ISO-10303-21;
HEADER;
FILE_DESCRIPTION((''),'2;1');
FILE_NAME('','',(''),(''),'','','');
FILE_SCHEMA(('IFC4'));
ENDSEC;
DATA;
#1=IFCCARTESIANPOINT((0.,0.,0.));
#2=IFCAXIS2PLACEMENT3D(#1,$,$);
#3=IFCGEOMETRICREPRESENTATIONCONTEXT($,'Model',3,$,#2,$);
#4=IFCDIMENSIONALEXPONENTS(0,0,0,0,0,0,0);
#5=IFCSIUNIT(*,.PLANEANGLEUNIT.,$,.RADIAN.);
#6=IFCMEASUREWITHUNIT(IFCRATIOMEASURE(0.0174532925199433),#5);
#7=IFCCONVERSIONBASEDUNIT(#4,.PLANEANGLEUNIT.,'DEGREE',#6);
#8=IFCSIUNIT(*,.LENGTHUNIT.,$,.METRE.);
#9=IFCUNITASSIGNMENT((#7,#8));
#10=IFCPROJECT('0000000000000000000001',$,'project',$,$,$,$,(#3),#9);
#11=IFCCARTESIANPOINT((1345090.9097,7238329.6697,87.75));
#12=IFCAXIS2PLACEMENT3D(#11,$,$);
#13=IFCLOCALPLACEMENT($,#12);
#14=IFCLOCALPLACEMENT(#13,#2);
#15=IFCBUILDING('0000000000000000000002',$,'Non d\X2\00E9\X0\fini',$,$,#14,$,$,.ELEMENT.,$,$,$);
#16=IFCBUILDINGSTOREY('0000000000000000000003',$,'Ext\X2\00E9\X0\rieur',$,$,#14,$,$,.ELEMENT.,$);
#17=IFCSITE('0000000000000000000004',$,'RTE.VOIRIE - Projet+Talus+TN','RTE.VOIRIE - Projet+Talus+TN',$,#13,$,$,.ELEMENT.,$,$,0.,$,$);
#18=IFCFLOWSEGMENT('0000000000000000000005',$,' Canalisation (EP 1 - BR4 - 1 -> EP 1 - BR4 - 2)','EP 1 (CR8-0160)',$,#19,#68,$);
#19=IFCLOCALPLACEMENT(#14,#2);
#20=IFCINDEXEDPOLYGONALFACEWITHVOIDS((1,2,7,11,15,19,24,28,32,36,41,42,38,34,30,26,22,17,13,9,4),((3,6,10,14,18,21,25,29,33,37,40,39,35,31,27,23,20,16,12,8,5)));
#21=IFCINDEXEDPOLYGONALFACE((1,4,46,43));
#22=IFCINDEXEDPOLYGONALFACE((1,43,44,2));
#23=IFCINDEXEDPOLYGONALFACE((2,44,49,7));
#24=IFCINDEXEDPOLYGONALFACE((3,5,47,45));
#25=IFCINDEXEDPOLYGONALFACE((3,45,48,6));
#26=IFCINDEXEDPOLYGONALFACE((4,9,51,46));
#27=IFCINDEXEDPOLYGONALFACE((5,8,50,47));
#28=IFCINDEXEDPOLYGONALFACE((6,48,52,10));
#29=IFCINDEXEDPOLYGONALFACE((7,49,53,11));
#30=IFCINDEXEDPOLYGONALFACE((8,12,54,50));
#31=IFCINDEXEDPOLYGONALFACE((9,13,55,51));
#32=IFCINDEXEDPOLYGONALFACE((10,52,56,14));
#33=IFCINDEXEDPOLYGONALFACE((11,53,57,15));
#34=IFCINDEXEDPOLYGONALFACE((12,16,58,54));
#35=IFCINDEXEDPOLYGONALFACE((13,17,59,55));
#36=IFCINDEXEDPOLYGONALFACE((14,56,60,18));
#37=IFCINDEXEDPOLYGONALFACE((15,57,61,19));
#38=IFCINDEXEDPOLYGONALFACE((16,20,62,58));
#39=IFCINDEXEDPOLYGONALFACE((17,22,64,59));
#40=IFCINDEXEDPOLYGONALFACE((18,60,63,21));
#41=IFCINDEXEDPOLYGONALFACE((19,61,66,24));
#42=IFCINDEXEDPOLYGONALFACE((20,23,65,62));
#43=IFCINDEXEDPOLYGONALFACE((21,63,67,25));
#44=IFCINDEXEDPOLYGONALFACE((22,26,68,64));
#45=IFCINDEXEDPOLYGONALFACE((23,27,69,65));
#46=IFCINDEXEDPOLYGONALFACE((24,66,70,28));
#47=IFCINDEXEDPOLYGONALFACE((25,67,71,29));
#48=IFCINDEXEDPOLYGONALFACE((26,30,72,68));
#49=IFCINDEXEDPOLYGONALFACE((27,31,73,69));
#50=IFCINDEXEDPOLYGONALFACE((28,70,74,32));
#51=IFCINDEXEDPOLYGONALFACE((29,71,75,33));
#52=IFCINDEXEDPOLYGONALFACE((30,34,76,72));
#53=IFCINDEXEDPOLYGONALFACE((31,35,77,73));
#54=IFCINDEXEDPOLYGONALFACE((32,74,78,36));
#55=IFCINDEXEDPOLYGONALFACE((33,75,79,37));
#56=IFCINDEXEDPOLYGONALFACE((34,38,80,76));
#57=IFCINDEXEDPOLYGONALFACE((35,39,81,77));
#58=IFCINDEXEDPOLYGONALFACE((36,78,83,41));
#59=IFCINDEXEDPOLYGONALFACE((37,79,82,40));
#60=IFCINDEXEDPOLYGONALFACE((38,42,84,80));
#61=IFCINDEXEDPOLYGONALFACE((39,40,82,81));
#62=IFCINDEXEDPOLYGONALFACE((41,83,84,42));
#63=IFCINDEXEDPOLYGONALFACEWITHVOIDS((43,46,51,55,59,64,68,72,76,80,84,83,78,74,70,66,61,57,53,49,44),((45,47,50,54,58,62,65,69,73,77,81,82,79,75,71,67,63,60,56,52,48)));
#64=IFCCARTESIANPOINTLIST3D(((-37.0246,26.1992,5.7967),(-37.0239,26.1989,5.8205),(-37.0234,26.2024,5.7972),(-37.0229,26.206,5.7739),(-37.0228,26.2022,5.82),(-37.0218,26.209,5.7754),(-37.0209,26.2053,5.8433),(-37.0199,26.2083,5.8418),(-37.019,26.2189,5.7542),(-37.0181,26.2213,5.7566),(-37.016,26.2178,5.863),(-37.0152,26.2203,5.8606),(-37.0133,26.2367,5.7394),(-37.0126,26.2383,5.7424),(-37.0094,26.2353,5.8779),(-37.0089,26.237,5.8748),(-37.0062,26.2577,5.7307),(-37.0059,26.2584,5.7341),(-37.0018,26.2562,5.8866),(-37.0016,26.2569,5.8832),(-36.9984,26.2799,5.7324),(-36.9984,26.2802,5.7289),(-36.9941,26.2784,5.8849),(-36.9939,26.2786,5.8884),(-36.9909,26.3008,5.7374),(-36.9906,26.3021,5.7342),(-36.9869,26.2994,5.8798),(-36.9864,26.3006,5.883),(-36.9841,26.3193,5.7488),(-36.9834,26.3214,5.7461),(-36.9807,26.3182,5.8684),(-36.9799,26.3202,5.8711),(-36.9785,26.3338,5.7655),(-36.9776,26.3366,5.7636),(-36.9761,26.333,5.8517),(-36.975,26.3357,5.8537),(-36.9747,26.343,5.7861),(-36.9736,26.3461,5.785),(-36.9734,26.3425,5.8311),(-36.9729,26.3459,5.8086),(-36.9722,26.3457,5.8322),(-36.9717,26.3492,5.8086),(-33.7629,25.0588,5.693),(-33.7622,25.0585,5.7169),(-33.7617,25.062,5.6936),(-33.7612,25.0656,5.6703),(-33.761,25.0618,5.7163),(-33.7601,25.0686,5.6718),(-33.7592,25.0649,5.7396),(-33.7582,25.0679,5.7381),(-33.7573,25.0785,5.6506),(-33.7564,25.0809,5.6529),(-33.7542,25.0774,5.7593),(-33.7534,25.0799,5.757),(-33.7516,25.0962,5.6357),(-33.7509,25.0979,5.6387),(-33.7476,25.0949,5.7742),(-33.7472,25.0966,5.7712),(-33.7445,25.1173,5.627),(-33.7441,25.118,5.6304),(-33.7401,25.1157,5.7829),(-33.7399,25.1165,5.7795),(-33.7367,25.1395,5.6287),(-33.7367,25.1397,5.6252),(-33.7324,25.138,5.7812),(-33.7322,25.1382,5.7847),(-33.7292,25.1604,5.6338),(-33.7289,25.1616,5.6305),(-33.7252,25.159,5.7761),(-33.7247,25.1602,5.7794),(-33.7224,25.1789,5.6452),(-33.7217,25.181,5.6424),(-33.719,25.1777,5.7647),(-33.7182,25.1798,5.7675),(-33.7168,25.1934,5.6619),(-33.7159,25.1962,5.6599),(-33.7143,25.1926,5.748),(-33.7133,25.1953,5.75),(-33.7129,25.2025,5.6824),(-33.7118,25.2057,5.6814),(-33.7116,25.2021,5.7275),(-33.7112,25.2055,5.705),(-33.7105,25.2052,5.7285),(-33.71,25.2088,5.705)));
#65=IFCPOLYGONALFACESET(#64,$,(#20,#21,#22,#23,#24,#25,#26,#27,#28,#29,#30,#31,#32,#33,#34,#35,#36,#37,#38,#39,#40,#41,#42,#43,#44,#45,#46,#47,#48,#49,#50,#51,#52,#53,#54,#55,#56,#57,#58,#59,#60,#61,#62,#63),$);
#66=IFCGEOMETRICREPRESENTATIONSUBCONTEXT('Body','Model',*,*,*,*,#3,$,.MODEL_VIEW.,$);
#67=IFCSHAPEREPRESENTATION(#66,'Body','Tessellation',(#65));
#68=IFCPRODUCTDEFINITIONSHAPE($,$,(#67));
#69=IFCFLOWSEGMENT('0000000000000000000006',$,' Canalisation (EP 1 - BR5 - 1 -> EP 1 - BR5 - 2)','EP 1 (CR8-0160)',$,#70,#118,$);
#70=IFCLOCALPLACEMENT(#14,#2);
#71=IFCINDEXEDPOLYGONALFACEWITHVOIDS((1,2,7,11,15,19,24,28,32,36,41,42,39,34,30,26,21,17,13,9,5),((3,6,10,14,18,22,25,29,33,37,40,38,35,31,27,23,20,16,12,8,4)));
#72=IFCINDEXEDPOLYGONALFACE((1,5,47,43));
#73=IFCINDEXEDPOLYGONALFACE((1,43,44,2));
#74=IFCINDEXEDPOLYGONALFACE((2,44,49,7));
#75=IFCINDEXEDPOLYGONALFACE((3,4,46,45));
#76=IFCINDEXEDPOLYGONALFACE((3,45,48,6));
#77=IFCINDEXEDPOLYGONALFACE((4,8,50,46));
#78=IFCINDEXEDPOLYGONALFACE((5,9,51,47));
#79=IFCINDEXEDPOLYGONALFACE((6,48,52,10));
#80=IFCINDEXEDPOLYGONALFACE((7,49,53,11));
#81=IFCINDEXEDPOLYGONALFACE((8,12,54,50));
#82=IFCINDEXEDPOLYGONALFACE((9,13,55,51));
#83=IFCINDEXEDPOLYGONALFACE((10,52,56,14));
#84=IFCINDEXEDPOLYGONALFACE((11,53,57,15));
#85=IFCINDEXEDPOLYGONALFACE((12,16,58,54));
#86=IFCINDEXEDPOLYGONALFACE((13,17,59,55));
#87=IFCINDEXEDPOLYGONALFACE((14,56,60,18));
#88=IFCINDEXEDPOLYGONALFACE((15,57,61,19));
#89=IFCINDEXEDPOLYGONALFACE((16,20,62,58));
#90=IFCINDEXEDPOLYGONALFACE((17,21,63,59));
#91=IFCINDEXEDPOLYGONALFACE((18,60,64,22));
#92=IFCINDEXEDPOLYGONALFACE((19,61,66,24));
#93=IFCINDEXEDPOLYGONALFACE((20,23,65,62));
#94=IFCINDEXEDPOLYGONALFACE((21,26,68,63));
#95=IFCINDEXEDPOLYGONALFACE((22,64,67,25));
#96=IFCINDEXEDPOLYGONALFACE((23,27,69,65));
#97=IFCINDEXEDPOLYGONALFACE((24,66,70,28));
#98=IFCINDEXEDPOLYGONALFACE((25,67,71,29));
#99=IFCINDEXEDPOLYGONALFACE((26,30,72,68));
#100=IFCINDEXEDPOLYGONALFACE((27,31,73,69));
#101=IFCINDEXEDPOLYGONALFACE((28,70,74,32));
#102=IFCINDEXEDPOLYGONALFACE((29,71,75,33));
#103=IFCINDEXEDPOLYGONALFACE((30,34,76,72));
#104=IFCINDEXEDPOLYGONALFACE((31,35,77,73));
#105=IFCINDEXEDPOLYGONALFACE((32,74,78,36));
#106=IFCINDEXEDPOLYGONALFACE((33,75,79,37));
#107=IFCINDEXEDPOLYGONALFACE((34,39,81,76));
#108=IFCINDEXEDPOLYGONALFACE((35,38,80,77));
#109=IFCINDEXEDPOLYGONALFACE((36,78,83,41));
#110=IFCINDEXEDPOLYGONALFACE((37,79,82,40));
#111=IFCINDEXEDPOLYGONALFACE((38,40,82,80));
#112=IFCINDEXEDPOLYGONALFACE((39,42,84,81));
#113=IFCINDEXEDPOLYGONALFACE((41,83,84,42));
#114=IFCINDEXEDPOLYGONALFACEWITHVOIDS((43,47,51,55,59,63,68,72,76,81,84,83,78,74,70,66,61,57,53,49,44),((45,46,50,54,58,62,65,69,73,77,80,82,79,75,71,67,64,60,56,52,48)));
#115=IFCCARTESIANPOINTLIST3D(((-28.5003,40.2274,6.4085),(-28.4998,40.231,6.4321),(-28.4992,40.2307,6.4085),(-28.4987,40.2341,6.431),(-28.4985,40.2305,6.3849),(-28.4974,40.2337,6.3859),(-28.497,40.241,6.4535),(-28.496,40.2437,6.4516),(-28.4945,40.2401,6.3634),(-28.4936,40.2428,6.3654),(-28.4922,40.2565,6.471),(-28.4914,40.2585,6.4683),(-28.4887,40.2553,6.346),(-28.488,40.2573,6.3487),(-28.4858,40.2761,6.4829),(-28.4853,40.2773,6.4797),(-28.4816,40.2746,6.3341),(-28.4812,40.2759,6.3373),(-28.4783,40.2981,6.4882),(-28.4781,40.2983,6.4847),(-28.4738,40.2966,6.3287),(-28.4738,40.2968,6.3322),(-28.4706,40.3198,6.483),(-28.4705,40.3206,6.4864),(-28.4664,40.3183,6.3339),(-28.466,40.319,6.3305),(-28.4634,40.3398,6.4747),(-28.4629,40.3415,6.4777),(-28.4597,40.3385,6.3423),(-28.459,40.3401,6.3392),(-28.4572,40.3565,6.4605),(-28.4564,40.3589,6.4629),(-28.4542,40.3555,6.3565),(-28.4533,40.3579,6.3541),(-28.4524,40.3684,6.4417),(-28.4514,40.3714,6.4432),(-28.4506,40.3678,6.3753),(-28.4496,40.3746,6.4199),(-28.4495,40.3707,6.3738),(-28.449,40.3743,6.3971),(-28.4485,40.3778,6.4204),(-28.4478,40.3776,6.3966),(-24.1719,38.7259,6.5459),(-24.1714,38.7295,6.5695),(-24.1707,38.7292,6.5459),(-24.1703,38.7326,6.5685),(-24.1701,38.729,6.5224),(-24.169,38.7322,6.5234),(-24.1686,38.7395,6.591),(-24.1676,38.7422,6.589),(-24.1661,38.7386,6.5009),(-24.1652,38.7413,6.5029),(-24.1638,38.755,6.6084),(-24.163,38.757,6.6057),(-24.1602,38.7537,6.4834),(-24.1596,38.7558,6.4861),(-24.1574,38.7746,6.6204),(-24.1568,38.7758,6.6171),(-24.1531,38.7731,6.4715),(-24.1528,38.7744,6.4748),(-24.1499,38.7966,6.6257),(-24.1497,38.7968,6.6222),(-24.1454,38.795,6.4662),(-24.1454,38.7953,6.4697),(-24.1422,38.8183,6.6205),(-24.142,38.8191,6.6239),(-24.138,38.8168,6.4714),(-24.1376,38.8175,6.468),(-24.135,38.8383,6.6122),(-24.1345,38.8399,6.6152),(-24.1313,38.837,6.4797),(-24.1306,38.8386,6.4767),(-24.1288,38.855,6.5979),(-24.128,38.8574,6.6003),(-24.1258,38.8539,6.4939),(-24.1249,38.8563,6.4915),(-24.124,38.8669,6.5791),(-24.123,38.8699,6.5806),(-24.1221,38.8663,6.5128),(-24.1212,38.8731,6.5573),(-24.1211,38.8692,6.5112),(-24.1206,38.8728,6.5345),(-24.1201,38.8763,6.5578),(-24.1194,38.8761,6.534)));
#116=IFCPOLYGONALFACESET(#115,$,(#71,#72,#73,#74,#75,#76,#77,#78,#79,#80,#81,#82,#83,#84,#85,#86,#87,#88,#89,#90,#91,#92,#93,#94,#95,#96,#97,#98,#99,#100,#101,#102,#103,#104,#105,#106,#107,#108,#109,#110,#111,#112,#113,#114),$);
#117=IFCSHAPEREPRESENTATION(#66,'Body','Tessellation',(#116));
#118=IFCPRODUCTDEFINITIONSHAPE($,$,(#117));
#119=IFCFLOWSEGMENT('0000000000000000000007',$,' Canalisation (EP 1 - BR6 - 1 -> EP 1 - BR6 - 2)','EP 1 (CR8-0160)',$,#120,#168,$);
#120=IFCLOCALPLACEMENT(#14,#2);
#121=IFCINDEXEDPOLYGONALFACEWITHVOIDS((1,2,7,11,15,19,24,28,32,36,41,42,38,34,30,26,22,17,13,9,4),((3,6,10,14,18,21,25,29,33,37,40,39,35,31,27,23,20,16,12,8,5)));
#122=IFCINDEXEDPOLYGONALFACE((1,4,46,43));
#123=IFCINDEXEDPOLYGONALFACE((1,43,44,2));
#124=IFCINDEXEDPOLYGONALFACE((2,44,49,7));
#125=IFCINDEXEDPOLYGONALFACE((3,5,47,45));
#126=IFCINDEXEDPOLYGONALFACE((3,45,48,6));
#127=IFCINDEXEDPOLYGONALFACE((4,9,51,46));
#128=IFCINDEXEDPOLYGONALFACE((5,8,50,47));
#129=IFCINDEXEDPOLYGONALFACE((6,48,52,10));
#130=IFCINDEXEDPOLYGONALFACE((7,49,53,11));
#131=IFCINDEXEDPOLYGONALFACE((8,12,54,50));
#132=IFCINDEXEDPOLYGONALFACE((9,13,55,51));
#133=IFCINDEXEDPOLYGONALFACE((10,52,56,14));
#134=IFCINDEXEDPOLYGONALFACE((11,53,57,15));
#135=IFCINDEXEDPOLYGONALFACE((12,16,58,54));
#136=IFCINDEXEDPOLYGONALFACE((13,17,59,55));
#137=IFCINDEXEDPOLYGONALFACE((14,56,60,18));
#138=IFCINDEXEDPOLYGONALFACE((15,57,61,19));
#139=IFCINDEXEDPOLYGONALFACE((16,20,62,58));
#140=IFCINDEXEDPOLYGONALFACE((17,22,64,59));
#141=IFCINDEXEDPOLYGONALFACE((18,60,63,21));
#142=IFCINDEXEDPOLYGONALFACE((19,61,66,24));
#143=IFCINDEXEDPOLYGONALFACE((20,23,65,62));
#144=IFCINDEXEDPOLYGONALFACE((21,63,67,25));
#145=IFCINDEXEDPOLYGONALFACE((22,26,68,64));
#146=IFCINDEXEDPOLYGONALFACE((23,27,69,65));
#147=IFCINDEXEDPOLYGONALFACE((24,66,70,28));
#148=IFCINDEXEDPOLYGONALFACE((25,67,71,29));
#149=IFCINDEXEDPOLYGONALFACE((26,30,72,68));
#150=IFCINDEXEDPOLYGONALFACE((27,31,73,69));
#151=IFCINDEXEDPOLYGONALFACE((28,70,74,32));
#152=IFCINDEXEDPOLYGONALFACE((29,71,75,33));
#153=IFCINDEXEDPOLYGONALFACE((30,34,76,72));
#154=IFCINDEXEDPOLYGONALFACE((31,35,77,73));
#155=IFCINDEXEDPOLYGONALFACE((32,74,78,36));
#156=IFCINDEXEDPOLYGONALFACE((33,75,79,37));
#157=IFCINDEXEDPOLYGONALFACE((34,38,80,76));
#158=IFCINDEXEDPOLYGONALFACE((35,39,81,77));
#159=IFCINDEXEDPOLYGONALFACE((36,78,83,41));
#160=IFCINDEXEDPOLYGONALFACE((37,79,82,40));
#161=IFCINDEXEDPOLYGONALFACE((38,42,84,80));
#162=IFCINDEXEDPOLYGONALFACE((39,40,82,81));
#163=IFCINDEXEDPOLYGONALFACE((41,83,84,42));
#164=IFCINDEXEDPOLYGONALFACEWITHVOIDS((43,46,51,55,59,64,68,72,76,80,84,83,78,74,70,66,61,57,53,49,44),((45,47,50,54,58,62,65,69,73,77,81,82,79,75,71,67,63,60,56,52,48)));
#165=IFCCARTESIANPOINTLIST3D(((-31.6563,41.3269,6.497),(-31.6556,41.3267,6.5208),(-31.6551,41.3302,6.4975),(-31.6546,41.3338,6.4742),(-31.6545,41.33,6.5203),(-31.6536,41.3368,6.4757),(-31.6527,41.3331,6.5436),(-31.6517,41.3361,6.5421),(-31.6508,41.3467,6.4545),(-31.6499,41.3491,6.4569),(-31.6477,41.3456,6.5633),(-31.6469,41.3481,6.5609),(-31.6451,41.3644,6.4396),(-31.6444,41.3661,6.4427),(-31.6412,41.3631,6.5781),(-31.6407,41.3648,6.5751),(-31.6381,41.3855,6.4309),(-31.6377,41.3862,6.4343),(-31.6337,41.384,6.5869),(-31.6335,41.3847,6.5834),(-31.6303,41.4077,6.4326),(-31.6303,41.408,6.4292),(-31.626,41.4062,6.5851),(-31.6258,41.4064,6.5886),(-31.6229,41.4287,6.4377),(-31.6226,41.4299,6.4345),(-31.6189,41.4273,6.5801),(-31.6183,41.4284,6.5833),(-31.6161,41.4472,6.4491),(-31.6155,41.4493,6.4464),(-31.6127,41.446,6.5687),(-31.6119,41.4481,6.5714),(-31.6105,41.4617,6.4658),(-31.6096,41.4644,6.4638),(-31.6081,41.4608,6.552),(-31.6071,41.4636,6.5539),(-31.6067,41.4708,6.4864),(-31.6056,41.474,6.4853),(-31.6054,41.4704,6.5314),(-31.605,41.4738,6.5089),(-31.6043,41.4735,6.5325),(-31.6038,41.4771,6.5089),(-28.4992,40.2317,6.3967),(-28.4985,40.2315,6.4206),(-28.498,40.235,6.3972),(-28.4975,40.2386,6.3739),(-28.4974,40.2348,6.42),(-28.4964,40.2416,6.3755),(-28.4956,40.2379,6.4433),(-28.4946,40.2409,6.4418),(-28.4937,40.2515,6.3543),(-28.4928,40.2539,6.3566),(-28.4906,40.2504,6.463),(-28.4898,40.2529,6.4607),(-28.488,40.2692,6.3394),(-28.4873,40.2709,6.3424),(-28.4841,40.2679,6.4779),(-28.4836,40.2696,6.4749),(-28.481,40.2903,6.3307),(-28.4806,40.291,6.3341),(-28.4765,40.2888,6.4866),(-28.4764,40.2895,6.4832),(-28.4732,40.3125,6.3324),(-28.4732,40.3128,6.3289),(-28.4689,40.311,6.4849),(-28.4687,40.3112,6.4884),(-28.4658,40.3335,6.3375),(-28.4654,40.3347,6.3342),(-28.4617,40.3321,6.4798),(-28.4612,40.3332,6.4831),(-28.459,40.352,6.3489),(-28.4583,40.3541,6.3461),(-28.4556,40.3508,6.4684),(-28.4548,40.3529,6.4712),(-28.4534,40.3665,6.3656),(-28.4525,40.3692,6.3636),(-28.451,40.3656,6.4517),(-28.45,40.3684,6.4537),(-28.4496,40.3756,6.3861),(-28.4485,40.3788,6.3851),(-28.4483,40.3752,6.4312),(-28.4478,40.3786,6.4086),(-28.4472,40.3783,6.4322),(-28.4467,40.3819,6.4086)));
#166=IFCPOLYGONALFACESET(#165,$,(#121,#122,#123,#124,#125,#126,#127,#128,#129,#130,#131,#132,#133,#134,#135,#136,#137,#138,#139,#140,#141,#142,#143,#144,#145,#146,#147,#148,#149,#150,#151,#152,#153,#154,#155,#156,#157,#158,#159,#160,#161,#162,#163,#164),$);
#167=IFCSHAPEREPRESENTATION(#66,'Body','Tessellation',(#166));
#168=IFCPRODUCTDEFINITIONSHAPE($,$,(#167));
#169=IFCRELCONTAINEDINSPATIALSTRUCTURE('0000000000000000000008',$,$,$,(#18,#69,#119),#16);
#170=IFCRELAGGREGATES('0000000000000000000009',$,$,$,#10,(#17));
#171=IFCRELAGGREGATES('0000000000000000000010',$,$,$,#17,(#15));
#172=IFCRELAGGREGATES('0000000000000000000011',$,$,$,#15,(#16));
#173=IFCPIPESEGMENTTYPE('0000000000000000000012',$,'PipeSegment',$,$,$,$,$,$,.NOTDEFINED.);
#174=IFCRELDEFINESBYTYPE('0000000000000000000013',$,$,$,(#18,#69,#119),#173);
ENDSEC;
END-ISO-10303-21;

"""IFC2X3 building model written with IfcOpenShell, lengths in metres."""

from ifc_helpers import new_model, entity, si_unit, converted_unit, frame, origin, origin_2d_with_axis, place, context, subcontext, project, spatial, hollow_circle, extrude, type_object, element, save


model = new_model("IFC2X3")

# Units and contexts
model_context = context("Model", 3, world=origin())
body_context = subcontext(model_context, "Body", "Model", "MODEL_VIEW")
ifc_project = project(units=[converted_unit("PLANEANGLEUNIT", "DEGREE", entity("IfcRatioMeasure", 0.0174532925199433), si_unit("PLANEANGLEUNIT", "RADIAN"), dimensions=[0, 0, 0, 0, 0, 0, 0]), si_unit("LENGTHUNIT", "METRE")], contexts=[model_context])

# Site, building, storey
site_placement = place(None, frame((1345090.9097, 7238329.6697, 87.75)))
site = spatial("IfcSite", under=ifc_project, at=site_placement, Name="RTE.VOIRIE - Projet+Talus+TN", Description="RTE.VOIRIE - Projet+Talus+TN", CompositionType="ELEMENT", RefElevation=0.0)
placement = place(site_placement, origin())
building = spatial("IfcBuilding", under=site, at=placement, Name="Non défini", CompositionType="ELEMENT")
storey = spatial("IfcBuildingStorey", under=building, at=placement, Name="Extérieur", CompositionType="ELEMENT")

# Flow segments
pipe_segment_type_1 = type_object("IfcPipeSegmentType", Name="PipeSegment", PredefinedType="NOTDEFINED")
flow_segment_1_placement = place(placement, origin())
element("IfcFlowSegment", 1, at=flow_segment_1_placement, inside=storey, type_object=pipe_segment_type_1, Name=" Canalisation (EP 1 - BR4 - 1 -> EP 1 - BR4 - 2)", Description="EP 1 (CR8-0160)", context=body_context, shape_type="SweptSolid", body=[
    extrude(hollow_circle(Radius=0.08, WallThickness=0.0035, at=origin_2d_with_axis()), frame((-36.9981, 26.2737, 5.8086), z_axis=(0.943542, -0.329894, -0.029987), x_axis=(0.329894, 0.943542, 0.0)), (0.0, 0.0, 1.0), 3.4569),
])
flow_segment_2_placement = place(placement, origin())
element("IfcFlowSegment", 2, at=flow_segment_2_placement, inside=storey, type_object=pipe_segment_type_1, Name=" Canalisation (EP 1 - BR5 - 1 -> EP 1 - BR5 - 2)", Description="EP 1 (CR8-0160)", context=body_context, shape_type="SweptSolid", body=[
    extrude(hollow_circle(Radius=0.08, WallThickness=0.0035, at=origin_2d_with_axis()), frame((-24.1457, 38.8015, 6.5459), z_axis=(-0.944344, 0.32759, -0.029987), x_axis=(-0.32759, -0.944344, 0.0)), (0.0, 0.0, 1.0), 4.5835),
])
flow_segment_3_placement = place(placement, origin())
element("IfcFlowSegment", 3, at=flow_segment_3_placement, inside=storey, type_object=pipe_segment_type_1, Name=" Canalisation (EP 1 - BR6 - 1 -> EP 1 - BR6 - 2)", Description="EP 1 (CR8-0160)", context=body_context, shape_type="SweptSolid", body=[
    extrude(hollow_circle(Radius=0.08, WallThickness=0.0035, at=origin_2d_with_axis()), frame((-31.63, 41.4015, 6.5089), z_axis=(0.944344, -0.32759, -0.029987), x_axis=(0.32759, 0.944344, 0.0)), (0.0, 0.0, 1.0), 3.3432),
])

save(model, "model.ifc")
